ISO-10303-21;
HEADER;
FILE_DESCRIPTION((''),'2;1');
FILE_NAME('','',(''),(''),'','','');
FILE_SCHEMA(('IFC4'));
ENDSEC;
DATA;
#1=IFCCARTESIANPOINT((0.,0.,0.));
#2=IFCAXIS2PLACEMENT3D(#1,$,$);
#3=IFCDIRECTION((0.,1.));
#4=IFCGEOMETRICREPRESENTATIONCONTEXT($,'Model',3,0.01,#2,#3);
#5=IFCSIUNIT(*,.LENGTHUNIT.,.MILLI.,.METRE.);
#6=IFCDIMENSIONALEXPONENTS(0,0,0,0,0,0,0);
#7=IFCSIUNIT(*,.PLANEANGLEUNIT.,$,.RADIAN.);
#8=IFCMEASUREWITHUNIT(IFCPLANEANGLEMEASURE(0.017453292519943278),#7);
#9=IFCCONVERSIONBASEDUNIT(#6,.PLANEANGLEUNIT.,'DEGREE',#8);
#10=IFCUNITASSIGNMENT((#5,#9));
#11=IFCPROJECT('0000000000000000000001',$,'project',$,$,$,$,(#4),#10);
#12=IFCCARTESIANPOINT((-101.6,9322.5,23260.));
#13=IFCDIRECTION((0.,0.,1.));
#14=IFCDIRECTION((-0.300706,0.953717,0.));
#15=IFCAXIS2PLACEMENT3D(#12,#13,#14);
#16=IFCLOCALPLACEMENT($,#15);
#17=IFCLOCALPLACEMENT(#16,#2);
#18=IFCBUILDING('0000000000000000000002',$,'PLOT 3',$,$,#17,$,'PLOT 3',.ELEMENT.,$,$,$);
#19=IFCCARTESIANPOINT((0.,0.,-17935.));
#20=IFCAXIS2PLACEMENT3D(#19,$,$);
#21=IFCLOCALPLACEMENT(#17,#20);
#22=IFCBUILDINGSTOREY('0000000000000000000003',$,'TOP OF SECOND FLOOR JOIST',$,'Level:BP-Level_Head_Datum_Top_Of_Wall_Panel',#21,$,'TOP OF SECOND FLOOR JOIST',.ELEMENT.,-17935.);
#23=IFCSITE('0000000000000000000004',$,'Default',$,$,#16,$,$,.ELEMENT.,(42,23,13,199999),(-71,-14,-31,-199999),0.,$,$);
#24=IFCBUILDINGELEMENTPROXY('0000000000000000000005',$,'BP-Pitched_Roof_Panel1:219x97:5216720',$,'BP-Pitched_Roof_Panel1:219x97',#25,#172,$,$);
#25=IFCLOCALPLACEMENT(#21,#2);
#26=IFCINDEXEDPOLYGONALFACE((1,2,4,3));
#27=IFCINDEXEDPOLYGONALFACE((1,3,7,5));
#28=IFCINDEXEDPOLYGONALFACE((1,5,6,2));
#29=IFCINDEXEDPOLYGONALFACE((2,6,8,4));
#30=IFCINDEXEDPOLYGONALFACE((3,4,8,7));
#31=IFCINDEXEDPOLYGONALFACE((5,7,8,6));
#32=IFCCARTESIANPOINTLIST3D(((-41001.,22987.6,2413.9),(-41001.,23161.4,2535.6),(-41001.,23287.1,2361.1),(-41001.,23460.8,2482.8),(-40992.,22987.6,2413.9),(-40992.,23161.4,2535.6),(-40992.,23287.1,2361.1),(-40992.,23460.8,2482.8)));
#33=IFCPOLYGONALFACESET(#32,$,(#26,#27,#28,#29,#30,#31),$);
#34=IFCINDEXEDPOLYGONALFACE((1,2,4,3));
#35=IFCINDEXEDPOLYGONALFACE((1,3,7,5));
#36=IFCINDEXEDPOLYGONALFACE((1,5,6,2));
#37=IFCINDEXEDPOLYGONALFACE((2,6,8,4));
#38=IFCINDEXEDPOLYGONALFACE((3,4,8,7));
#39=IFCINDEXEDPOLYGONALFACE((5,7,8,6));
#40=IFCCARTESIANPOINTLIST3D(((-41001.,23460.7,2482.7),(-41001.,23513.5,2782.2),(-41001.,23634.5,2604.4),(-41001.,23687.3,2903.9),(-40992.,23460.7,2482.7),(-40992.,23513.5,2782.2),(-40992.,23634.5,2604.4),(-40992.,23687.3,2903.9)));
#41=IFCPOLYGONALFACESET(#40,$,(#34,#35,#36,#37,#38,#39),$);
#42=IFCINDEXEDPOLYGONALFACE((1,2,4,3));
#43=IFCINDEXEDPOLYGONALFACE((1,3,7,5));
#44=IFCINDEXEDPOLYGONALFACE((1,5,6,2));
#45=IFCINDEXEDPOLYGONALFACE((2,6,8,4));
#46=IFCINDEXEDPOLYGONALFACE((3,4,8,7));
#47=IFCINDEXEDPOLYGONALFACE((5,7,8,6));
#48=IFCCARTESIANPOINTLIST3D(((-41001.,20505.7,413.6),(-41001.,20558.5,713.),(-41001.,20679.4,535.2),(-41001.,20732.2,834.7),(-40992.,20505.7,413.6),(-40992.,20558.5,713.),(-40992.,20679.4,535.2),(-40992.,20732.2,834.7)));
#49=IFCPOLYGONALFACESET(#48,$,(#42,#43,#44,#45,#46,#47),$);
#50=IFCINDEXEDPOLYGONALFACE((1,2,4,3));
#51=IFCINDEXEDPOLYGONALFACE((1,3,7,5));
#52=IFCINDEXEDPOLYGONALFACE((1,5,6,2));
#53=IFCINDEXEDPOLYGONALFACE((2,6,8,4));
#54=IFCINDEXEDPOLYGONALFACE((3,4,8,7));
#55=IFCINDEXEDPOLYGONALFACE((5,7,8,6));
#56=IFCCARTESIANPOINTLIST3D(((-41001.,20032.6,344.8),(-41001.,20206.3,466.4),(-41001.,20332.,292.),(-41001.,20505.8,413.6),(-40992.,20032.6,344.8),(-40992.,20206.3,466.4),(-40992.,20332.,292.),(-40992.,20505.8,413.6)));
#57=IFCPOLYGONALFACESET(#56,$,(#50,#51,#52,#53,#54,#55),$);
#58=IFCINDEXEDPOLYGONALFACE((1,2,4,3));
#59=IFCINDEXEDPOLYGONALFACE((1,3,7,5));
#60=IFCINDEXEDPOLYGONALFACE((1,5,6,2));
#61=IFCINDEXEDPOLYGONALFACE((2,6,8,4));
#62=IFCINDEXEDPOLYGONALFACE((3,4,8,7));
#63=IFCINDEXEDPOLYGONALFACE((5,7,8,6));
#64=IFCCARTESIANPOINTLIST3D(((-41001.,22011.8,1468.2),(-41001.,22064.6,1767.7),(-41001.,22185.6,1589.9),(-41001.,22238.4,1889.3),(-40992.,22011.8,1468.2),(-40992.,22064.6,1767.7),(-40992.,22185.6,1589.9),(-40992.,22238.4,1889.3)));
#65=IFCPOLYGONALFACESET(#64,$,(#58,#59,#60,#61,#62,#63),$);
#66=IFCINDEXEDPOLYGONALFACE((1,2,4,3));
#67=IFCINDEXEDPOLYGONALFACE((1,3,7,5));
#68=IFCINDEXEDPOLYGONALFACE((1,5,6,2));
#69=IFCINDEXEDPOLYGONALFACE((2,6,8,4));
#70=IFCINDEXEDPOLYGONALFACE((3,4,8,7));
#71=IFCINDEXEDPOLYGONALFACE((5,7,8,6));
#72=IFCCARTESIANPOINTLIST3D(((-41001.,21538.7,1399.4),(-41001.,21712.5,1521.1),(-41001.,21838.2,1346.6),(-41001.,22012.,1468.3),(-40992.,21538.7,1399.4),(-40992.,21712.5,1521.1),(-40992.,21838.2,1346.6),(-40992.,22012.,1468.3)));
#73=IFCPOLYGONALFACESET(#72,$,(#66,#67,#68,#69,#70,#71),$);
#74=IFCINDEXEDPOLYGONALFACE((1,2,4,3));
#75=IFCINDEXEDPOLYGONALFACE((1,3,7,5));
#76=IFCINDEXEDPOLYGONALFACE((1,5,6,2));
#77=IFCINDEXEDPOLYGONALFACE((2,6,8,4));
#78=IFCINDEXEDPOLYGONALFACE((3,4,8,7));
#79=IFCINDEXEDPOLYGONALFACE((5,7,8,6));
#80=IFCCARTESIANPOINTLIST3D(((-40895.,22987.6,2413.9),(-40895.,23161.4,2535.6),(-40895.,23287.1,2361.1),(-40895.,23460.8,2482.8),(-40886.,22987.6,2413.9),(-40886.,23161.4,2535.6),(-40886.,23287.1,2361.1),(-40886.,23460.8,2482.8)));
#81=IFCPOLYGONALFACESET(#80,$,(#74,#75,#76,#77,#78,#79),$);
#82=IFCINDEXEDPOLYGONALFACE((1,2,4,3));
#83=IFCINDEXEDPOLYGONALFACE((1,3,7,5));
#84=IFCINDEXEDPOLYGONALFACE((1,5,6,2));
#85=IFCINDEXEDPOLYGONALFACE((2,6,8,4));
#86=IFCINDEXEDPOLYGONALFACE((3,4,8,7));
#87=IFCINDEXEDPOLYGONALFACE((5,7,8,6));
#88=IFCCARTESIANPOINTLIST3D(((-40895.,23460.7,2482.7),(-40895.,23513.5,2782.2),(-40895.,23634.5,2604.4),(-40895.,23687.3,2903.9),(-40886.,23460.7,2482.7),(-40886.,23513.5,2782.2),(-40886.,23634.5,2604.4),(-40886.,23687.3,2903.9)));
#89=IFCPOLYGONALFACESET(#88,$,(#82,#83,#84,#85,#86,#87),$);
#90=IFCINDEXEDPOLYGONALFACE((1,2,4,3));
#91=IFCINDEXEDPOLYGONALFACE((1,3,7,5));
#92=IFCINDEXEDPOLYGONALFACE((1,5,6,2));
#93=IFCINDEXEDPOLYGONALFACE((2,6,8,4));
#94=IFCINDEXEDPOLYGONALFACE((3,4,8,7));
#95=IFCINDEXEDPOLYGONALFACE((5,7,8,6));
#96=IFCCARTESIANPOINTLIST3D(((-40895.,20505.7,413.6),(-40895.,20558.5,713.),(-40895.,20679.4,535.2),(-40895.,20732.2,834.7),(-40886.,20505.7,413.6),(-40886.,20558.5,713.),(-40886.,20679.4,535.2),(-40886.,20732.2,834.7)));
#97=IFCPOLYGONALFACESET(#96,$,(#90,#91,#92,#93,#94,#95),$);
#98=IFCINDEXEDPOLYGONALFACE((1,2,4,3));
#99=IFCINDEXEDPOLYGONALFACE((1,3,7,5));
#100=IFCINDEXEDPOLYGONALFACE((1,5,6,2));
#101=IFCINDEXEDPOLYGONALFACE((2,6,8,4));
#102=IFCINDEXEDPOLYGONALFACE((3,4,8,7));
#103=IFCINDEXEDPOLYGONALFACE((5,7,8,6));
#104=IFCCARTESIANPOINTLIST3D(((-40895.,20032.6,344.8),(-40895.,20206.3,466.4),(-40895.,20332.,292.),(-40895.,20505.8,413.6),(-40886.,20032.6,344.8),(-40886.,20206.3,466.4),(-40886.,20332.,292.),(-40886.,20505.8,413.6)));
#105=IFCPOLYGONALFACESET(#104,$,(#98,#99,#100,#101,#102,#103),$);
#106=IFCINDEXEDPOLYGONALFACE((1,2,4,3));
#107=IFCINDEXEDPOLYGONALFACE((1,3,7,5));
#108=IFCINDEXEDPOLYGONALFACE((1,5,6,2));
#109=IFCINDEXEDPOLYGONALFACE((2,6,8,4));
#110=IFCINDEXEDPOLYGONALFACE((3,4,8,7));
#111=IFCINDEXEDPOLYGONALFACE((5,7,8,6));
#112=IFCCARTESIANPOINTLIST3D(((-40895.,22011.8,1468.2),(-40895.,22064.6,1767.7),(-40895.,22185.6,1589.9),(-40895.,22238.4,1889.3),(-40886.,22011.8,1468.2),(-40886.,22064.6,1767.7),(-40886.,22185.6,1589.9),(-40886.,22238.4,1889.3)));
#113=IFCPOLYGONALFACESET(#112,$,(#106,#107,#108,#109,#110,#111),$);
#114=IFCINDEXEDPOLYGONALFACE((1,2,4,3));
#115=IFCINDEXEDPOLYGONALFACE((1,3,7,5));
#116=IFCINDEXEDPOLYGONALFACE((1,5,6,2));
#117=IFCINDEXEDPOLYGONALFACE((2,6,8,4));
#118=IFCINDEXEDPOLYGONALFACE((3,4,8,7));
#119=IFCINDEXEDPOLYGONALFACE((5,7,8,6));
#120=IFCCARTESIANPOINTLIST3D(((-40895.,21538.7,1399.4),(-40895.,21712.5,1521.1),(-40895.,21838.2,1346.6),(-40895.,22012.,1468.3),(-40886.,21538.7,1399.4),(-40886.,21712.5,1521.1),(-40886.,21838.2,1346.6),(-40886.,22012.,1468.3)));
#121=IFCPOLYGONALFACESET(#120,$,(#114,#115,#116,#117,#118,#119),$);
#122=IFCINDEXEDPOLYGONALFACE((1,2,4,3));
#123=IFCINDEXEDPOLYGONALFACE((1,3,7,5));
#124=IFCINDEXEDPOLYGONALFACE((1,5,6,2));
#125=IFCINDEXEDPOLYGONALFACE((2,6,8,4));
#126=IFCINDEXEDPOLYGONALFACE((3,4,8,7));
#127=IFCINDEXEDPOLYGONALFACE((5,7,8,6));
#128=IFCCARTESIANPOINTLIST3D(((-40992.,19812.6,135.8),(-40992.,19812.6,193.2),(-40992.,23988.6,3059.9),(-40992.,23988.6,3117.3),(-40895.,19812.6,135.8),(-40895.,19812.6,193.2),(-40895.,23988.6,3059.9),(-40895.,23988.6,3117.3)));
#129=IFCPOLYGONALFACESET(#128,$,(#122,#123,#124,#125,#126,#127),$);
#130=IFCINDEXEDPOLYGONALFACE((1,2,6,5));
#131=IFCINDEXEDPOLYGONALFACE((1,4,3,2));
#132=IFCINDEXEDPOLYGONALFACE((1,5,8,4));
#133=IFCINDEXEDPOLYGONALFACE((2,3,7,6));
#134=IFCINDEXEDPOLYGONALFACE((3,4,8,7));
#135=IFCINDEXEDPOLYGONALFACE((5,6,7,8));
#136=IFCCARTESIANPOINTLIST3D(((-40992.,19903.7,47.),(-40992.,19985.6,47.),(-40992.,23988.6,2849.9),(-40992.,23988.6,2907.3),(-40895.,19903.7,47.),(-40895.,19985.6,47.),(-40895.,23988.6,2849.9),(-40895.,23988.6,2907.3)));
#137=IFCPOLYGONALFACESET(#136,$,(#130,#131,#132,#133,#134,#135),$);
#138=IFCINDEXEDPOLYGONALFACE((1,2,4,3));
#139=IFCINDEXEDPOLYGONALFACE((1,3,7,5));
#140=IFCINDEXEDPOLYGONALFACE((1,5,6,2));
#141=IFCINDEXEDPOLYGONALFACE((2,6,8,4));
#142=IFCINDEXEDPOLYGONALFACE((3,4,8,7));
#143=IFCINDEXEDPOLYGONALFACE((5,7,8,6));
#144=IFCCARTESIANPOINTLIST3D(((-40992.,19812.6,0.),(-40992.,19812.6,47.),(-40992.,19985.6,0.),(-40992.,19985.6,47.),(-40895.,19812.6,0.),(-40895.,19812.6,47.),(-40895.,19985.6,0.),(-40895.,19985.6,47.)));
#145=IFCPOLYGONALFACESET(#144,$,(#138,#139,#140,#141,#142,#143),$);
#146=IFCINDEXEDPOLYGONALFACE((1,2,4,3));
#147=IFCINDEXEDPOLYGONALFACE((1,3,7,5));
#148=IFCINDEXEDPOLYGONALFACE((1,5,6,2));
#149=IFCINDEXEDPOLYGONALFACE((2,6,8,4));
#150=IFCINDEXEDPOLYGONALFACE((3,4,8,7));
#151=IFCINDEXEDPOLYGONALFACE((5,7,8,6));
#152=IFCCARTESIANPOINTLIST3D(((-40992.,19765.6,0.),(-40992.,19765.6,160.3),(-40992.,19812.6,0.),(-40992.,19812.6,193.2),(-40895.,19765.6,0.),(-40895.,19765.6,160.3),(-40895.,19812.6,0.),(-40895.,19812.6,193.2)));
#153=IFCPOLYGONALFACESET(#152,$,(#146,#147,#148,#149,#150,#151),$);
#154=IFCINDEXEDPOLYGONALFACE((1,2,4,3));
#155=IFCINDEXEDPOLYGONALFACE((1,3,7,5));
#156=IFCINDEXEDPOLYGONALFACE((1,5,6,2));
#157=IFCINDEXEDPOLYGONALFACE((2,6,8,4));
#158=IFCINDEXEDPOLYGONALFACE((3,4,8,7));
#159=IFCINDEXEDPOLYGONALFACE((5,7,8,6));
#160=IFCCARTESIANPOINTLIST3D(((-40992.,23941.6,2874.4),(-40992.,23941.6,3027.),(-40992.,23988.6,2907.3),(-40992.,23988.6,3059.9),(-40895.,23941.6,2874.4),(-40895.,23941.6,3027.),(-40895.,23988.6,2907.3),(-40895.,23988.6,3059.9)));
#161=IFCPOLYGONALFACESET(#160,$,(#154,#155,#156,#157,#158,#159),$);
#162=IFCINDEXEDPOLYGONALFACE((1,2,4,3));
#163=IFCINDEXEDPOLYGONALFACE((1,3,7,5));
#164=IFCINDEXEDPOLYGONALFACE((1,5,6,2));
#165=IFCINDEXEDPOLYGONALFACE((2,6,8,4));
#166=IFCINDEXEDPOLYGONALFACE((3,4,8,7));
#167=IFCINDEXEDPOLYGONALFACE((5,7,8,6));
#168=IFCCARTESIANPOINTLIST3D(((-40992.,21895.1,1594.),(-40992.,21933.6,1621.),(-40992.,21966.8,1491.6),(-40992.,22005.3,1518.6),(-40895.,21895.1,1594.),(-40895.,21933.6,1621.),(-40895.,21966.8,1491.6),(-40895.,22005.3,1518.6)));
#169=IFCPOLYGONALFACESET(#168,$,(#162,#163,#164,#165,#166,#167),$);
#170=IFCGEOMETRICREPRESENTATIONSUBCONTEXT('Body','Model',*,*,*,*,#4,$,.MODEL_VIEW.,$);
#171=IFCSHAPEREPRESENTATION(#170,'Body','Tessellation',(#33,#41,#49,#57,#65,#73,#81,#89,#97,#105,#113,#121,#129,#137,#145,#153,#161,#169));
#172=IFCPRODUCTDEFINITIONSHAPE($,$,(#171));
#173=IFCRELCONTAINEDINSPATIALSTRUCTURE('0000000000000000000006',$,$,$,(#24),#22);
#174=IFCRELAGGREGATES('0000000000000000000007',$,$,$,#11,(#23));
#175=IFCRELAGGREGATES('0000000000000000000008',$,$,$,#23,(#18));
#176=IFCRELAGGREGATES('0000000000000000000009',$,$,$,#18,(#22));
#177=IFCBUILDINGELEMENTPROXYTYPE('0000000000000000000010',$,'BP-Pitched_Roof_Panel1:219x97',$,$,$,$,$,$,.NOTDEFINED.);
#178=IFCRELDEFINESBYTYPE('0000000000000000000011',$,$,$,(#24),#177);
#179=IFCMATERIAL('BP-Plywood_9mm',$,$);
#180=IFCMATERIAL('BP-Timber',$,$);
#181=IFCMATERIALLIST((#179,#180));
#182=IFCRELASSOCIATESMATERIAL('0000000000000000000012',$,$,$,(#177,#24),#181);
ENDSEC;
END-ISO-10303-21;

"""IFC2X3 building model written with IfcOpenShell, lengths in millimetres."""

from ifc_helpers import new_model, entity, si_unit, converted_unit, direction, frame, frame_2d, origin, origin_2d_with_axis, place, context, subcontext, project, spatial, polyline, rectangle, outline, extrude, source, transform, mapped, material, material_list, type_object, type_shapes, element, save


model = new_model("IFC2X3")

# Units and contexts
model_context = context("Model", 3, precision=0.01, world=origin(), true_north=direction((0.0, 1.0)))
body_context = subcontext(model_context, "Body", "Model", "MODEL_VIEW")
ifc_project = project(units=[si_unit("LENGTHUNIT", "METRE", prefix="MILLI"), converted_unit("PLANEANGLEUNIT", "DEGREE", entity("IfcPlaneAngleMeasure", 0.017453292519943278), si_unit("PLANEANGLEUNIT", "RADIAN"), dimensions=[0, 0, 0, 0, 0, 0, 0])], contexts=[model_context])

# Site, building, storey
site_placement = place(None, frame((-101.6, 9322.5, 23260.0), z_axis=(0.0, 0.0, 1.0), x_axis=(-0.300706, 0.953717, 0.0)))
site = spatial("IfcSite", under=ifc_project, at=site_placement, Name="Default", CompositionType="ELEMENT", RefLatitude=(42, 23, 13, 199999), RefLongitude=(-71, -14, -31, -199999), RefElevation=0.0)
building_placement = place(site_placement, origin())
building = spatial("IfcBuilding", under=site, at=building_placement, Name="PLOT 3", LongName="PLOT 3", CompositionType="ELEMENT")
storey_placement = place(building_placement, frame((0.0, 0.0, -17935.0)))
storey = spatial("IfcBuildingStorey", under=building, at=storey_placement, Name="TOP OF SECOND FLOOR JOIST", ObjectType="Level:BP-Level_Head_Datum_Top_Of_Wall_Panel", LongName="TOP OF SECOND FLOOR JOIST", CompositionType="ELEMENT", Elevation=-17935.0)

# Building element proxy
ifc_material_1 = material(Name="BP-Timber")
ifc_material_2 = material(Name="BP-Plywood_9mm")
ifc_material_list = material_list([ifc_material_2, ifc_material_1])
building_element_proxy_type_1 = type_object("IfcBuildingElementProxyType", Name="BP-Pitched_Roof_Panel1:219x97", PredefinedType="NOTDEFINED", material=ifc_material_list)
shared_shape_1 = source(origin(), body_context, "Body", "SweptSolid", [
    extrude(outline(polyline([(-77.0, -75.0), (227.0, -75.0), (77.0, 75.0), (-227.0, 75.0), (-77.0, -75.0)])), frame((36.3, 3947.0, 2448.4), z_axis=(0.0, 1.0, 0.0), x_axis=(-0.984808, 0.0, 0.173648)), (0.0, 0.0, 1.0), 9.0),
    extrude(outline(polyline([(1.4, -107.5), (213.6, -107.5), (-1.4, 107.5), (-213.6, 107.5), (1.4, -107.5)])), frame((386.1, 3947.0, 2693.3), z_axis=(0.0, 1.0, 0.0), x_axis=(-0.819152, 0.0, -0.573576)), (0.0, 0.0, 1.0), 9.0),
    extrude(outline(polyline([(1.4, -107.5), (213.6, -107.5), (-1.4, 107.5), (-213.6, 107.5), (1.4, -107.5)])), frame((-2569.0, 3947.0, 624.1), z_axis=(0.0, 1.0, 0.0), x_axis=(-0.819152, 0.0, -0.573576)), (0.0, 0.0, 1.0), 9.0),
    extrude(outline(polyline([(-77.0, -75.0), (227.0, -75.0), (77.0, 75.0), (-227.0, 75.0), (-77.0, -75.0)])), frame((-2918.8, 3947.0, 379.2), z_axis=(0.0, 1.0, 0.0), x_axis=(-0.984808, 0.0, 0.173648)), (0.0, 0.0, 1.0), 9.0),
    extrude(outline(polyline([(1.4, -107.5), (213.6, -107.5), (-1.4, 107.5), (-213.6, 107.5), (1.4, -107.5)])), frame((-1062.8, 3947.0, 1678.8), z_axis=(0.0, 1.0, 0.0), x_axis=(-0.819152, 0.0, -0.573576)), (0.0, 0.0, 1.0), 9.0),
    extrude(outline(polyline([(-77.0, -75.0), (227.0, -75.0), (77.0, 75.0), (-227.0, 75.0), (-77.0, -75.0)])), frame((-1412.6, 3947.0, 1433.9), z_axis=(0.0, 1.0, 0.0), x_axis=(-0.984808, 0.0, 0.173648)), (0.0, 0.0, 1.0), 9.0),
    extrude(outline(polyline([(-77.0, -75.0), (227.0, -75.0), (77.0, 75.0), (-227.0, 75.0), (-77.0, -75.0)])), frame((36.3, 3841.0, 2448.4), z_axis=(0.0, 1.0, 0.0), x_axis=(-0.984808, 0.0, 0.173648)), (0.0, 0.0, 1.0), 9.0),
    extrude(outline(polyline([(1.4, -107.5), (213.6, -107.5), (-1.4, 107.5), (-213.6, 107.5), (1.4, -107.5)])), frame((386.1, 3841.0, 2693.3), z_axis=(0.0, 1.0, 0.0), x_axis=(-0.819152, 0.0, -0.573576)), (0.0, 0.0, 1.0), 9.0),
    extrude(outline(polyline([(1.4, -107.5), (213.6, -107.5), (-1.4, 107.5), (-213.6, 107.5), (1.4, -107.5)])), frame((-2569.0, 3841.0, 624.1), z_axis=(0.0, 1.0, 0.0), x_axis=(-0.819152, 0.0, -0.573576)), (0.0, 0.0, 1.0), 9.0),
    extrude(outline(polyline([(-77.0, -75.0), (227.0, -75.0), (77.0, 75.0), (-227.0, 75.0), (-77.0, -75.0)])), frame((-2918.8, 3841.0, 379.2), z_axis=(0.0, 1.0, 0.0), x_axis=(-0.984808, 0.0, 0.173648)), (0.0, 0.0, 1.0), 9.0),
    extrude(outline(polyline([(1.4, -107.5), (213.6, -107.5), (-1.4, 107.5), (-213.6, 107.5), (1.4, -107.5)])), frame((-1062.8, 3841.0, 1678.8), z_axis=(0.0, 1.0, 0.0), x_axis=(-0.819152, 0.0, -0.573576)), (0.0, 0.0, 1.0), 9.0),
    extrude(outline(polyline([(-77.0, -75.0), (227.0, -75.0), (77.0, 75.0), (-227.0, 75.0), (-77.0, -75.0)])), frame((-1412.6, 3841.0, 1433.9), z_axis=(0.0, 1.0, 0.0), x_axis=(-0.984808, 0.0, 0.173648)), (0.0, 0.0, 1.0), 9.0),
    extrude(outline(polyline([(-1490.7, -2088.0), (-1433.3, -2088.0), (1490.7, 2088.0), (1433.3, 2088.0), (-1490.7, -2088.0)])), frame((-1287.3, 3850.0, 1626.6), z_axis=(0.0, 1.0, 0.0), x_axis=(0.0, 0.0, -1.0)), (0.0, 0.0, 1.0), 97.0),
    extrude(outline(polyline([(-1444.5, -2022.0), (-1387.1, -2022.0), (1415.8, 1981.0), (1415.8, 2063.0), (-1444.5, -2022.0)])), frame((-1221.3, 3850.0, 1462.8), z_axis=(0.0, 1.0, 0.0), x_axis=(0.0, 0.0, -1.0)), (0.0, 0.0, 1.0), 97.0),
    extrude(rectangle(XDim=97.0, YDim=173.0, at=origin_2d_with_axis()), frame((-3288.8, 3898.5, 0.0), z_axis=(0.0, 0.0, 1.0), x_axis=(0.0, 1.0, 0.0)), (0.0, 0.0, 1.0), 47.0),
    extrude(outline(polyline([(22.0, -72.4), (79.4, -72.4), (-31.4, 85.9), (-69.9, 58.9), (22.0, -72.4)])), frame((-3398.8, 3850.0, 88.4), z_axis=(0.0, 1.0, 0.0), x_axis=(0.819152, 0.0, 0.573576)), (0.0, 0.0, 1.0), 97.0),
    extrude(outline(polyline([(15.1, -62.5), (72.5, -62.5), (-15.1, 62.5), (-72.5, 62.5), (15.1, -62.5)])), frame((777.2, 3850.0, 2967.2), z_axis=(0.0, 1.0, 0.0), x_axis=(0.819152, 0.0, 0.573576)), (0.0, 0.0, 1.0), 97.0),
    extrude(rectangle(XDim=47.0, YDim=97.0, at=frame_2d((0.0, 0.0), x_axis=(0.0, 1.0))), frame((-1201.9, 3898.5, 1505.1), z_axis=(-0.573576, 0.0, 0.819152), x_axis=(0.0, 1.0, 0.0)), (0.0, 0.0, 1.0), 125.0),
])
type_shapes(building_element_proxy_type_1, [shared_shape_1])
for number, where, z_axis, x_axis, name in (
    (1, (-37045.0, 23187.9, 0.0), (0.0, 0.0, 1.0), (0.0, 1.0, 0.0), "BP-Pitched_Roof_Panel1:219x97:5216720"),
):
    element("IfcBuildingElementProxy", number, at=place(storey_placement, frame(where, z_axis=z_axis, x_axis=x_axis)), inside=storey, type_object=building_element_proxy_type_1, material=ifc_material_list, Name=name, ObjectType="BP-Pitched_Roof_Panel1:219x97", context=body_context, shape_type="MappedRepresentation", body=[
        mapped(shared_shape_1, transform((0.0, 0.0, 0.0), scale=1.0)),
    ])

save(model, "model.ifc")
